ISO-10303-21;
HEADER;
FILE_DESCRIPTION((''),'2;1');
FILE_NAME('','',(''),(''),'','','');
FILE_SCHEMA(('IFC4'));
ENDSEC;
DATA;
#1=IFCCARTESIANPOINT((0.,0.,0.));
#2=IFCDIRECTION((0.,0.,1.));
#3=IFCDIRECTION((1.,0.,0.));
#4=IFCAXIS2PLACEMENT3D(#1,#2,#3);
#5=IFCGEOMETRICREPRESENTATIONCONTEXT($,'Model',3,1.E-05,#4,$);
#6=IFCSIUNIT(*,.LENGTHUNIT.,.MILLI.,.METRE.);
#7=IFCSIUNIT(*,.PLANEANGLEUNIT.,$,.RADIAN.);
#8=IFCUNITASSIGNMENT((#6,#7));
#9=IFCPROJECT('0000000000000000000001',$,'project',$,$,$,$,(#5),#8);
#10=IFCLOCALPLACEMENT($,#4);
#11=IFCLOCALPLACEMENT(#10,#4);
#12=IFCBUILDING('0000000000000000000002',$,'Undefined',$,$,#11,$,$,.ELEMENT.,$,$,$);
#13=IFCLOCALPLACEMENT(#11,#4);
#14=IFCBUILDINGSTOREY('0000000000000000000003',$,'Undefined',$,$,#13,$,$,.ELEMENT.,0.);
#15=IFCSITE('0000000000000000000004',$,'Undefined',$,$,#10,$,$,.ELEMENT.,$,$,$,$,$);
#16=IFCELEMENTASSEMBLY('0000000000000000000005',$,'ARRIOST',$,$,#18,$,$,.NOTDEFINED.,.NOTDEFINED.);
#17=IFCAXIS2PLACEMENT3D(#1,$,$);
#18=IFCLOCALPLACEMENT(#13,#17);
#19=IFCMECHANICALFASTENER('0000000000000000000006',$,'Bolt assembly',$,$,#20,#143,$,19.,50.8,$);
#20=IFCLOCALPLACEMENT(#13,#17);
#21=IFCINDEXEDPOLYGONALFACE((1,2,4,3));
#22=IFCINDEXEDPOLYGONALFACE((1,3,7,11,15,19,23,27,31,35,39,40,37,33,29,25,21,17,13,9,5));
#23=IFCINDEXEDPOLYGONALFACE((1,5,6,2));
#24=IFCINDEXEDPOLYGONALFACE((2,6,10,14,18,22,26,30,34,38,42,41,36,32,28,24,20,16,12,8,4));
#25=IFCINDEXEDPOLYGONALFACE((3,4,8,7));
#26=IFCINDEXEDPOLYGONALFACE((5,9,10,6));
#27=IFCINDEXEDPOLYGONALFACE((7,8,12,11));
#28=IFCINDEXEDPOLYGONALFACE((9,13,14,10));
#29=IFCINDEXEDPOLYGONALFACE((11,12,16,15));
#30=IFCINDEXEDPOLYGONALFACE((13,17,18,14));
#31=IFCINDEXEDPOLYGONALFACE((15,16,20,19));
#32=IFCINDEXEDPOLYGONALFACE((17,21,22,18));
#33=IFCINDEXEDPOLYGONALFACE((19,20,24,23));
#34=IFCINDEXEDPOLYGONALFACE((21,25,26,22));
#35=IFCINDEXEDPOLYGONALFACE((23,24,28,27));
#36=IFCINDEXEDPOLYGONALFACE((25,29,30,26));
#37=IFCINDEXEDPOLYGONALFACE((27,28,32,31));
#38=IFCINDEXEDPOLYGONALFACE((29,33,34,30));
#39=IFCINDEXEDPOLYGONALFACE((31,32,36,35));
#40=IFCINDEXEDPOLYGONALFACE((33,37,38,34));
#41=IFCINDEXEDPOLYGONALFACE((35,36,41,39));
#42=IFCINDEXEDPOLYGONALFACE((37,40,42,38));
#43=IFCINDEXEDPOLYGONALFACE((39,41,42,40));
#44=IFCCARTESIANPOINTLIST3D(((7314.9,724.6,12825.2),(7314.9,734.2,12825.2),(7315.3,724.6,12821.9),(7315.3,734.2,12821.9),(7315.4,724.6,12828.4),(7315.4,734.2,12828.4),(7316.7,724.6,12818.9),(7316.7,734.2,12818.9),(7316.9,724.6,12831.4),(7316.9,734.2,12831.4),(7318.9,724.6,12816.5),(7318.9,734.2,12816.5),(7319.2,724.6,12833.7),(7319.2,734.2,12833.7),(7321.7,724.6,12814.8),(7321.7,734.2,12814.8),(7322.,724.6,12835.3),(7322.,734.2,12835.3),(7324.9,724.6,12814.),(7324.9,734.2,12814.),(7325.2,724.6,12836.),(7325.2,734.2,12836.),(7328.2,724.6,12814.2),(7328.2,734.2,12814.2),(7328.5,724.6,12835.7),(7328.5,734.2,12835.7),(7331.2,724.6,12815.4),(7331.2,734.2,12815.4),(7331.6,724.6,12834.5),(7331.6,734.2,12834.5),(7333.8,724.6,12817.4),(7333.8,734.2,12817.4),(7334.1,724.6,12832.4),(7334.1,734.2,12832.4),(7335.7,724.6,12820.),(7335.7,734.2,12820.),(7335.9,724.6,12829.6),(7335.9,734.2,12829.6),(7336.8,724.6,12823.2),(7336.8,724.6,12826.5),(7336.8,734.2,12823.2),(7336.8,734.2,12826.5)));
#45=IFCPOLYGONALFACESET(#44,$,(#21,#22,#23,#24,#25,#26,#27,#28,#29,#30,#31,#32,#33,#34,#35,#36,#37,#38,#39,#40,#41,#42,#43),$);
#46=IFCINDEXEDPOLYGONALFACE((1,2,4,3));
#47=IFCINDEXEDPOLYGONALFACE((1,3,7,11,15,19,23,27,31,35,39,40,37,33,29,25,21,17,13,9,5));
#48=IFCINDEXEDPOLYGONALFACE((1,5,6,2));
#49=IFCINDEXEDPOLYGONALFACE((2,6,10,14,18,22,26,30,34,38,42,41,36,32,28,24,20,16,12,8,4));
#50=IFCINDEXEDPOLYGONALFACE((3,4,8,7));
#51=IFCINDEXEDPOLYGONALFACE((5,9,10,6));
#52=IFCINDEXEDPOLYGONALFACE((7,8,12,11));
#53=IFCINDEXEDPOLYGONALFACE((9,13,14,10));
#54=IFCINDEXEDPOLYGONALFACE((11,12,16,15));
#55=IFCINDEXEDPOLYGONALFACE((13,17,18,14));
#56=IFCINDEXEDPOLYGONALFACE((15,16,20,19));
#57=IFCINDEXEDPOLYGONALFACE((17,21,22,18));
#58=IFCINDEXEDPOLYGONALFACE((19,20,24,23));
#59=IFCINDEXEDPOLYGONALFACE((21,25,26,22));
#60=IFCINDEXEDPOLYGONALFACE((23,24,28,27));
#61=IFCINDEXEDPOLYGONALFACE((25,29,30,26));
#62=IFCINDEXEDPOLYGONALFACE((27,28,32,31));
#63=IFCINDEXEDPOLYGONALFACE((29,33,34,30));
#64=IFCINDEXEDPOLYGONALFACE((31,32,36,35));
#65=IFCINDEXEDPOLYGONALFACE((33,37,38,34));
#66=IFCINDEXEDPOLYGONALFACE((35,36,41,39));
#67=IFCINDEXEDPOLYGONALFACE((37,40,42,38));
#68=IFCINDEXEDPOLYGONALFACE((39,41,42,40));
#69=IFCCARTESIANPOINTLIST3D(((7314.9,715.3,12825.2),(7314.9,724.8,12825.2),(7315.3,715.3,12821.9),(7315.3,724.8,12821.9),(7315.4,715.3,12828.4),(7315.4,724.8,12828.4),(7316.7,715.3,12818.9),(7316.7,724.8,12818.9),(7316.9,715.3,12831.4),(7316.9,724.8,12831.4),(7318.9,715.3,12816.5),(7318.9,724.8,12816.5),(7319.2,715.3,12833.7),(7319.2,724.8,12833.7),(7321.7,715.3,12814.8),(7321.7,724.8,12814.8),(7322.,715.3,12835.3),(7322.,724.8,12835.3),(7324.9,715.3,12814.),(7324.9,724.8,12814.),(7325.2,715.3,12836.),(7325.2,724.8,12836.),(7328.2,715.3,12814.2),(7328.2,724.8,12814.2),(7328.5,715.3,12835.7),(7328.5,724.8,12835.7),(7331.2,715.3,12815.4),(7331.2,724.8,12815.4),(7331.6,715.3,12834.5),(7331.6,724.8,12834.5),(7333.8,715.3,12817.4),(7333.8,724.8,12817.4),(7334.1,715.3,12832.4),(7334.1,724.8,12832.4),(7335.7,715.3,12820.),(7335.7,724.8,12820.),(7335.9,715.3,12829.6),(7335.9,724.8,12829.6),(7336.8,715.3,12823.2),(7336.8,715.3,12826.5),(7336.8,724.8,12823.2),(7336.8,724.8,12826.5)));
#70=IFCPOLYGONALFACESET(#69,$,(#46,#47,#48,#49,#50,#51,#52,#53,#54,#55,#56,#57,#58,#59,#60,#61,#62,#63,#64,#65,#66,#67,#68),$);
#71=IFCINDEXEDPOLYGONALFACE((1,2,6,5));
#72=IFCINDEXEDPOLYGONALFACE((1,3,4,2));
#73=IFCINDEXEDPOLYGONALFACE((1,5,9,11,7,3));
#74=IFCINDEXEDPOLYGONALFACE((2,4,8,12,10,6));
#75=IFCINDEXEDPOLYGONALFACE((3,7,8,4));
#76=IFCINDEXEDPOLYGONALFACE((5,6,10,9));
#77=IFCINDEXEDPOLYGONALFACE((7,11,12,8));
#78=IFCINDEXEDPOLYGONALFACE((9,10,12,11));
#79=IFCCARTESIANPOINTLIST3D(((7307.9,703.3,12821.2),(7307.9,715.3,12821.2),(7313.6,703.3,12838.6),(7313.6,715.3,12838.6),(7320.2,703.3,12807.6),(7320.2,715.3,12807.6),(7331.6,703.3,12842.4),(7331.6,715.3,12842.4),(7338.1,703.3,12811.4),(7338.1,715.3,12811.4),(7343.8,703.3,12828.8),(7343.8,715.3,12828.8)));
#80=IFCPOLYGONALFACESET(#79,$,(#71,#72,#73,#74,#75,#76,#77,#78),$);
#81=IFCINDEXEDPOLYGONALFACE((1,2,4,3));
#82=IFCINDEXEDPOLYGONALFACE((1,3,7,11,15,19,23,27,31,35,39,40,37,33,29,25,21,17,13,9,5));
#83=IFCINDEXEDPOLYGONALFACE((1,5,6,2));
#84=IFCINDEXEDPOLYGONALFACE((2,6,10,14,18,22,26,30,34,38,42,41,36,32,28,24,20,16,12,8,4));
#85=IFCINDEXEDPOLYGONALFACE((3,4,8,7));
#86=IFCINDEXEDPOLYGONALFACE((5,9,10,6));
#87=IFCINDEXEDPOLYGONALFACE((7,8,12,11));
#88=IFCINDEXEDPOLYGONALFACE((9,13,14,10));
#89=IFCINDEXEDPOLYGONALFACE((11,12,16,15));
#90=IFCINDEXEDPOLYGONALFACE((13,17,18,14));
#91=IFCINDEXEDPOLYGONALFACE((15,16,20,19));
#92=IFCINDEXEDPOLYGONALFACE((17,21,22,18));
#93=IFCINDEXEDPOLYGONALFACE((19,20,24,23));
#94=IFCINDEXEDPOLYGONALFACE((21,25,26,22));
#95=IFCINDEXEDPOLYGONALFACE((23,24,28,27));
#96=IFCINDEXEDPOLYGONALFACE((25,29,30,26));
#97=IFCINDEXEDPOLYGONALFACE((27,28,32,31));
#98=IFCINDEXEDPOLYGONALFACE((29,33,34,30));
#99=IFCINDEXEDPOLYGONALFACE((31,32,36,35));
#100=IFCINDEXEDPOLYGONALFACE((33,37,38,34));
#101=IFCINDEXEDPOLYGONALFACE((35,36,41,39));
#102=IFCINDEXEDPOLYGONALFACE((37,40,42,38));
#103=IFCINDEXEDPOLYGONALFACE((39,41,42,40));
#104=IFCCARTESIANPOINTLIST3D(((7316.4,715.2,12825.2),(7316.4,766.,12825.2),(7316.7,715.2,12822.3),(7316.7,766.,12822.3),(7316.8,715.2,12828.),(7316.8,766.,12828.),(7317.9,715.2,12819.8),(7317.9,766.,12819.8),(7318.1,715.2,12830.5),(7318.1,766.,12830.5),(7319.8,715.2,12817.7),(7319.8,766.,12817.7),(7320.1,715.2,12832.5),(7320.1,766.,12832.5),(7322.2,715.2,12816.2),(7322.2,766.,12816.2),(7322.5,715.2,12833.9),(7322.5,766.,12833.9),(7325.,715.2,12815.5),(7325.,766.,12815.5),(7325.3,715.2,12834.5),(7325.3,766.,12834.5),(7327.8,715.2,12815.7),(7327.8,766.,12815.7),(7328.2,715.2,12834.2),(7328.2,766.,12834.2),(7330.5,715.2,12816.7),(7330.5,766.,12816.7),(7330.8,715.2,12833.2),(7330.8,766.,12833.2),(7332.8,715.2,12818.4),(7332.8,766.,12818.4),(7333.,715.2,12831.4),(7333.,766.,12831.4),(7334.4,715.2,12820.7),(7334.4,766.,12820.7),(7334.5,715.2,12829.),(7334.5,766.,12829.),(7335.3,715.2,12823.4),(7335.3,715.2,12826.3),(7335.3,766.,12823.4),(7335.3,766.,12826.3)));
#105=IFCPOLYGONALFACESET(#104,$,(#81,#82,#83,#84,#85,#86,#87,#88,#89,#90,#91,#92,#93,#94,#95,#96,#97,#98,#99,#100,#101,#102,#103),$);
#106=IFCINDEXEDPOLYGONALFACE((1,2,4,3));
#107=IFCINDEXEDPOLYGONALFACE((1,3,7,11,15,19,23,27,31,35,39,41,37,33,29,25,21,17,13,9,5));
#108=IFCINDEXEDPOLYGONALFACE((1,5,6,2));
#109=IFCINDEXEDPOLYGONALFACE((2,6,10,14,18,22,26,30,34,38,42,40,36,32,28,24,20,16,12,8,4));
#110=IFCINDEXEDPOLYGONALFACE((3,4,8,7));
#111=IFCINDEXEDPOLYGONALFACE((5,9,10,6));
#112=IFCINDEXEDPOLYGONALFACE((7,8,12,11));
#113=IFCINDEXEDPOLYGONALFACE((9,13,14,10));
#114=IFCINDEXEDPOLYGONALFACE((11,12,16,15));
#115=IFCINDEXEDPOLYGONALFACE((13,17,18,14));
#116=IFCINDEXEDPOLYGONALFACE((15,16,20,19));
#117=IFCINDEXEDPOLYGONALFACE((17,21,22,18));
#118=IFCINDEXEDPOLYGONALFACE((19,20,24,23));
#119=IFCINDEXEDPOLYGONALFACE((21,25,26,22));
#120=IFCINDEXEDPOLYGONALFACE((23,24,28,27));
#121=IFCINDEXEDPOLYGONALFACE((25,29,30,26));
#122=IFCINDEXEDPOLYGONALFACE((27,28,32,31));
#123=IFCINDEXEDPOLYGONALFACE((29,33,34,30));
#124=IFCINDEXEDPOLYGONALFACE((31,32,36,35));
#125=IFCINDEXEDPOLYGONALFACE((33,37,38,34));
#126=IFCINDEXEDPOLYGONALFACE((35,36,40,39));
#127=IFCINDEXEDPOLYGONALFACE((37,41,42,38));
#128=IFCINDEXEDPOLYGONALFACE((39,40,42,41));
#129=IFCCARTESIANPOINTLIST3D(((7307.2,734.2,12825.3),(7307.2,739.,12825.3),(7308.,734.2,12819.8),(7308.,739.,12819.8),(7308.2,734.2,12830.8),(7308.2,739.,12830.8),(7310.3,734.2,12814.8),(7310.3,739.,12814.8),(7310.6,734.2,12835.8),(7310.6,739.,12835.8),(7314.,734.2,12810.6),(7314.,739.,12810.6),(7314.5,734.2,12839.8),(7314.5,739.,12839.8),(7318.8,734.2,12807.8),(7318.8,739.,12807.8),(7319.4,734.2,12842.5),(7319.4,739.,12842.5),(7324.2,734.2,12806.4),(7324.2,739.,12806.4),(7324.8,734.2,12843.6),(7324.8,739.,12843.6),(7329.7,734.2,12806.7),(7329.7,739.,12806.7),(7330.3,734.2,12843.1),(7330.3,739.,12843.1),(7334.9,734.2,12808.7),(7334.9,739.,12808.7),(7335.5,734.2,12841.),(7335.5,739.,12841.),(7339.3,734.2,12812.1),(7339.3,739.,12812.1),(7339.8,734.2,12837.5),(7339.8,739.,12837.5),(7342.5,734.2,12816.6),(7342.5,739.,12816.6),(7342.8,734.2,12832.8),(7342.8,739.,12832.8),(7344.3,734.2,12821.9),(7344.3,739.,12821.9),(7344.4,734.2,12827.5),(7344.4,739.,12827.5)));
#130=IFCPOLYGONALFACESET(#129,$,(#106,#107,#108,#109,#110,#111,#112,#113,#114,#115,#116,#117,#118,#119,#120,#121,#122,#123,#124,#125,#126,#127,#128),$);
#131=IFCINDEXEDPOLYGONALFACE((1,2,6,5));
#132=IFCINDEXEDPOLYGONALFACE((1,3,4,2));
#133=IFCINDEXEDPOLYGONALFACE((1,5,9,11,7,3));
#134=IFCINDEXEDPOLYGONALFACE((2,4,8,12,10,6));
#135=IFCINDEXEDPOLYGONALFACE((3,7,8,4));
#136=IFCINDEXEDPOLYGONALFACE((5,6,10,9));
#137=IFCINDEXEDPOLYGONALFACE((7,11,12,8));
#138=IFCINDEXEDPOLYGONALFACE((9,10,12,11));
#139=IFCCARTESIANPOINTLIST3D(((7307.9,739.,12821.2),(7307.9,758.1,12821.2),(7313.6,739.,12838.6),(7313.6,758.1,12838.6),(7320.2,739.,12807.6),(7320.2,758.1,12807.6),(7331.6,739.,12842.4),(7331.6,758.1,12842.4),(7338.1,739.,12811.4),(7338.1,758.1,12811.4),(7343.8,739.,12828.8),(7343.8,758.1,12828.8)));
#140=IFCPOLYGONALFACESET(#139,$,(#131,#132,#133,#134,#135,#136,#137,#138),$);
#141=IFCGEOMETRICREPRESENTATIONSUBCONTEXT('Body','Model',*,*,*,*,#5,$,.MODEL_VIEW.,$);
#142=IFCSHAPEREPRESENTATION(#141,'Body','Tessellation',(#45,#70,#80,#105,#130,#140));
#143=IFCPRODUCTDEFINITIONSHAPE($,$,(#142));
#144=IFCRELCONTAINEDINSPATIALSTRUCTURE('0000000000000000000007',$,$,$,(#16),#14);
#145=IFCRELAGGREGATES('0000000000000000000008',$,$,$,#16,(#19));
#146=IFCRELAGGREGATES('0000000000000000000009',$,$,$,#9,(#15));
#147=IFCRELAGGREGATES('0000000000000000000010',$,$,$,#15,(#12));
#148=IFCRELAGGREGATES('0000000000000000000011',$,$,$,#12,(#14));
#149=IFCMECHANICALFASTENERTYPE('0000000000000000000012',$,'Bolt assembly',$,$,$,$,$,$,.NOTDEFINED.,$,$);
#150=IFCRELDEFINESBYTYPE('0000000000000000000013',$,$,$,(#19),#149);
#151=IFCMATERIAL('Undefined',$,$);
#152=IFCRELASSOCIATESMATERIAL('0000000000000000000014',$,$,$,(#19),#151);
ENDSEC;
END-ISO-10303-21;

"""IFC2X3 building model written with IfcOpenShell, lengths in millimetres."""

from ifc_helpers import new_model, si_unit, frame, origin_with_axes, origin_2d_with_axis, place, context, subcontext, project, spatial, polyline, circle, outline, extrude, source, transform, mapped, material, type_object, element, aggregate, save


model = new_model("IFC2X3")

# Units and contexts
model_context = context("Model", 3, precision=1e-05, world=origin_with_axes())
body_context = subcontext(model_context, "Body", "Model", "MODEL_VIEW")
ifc_project = project(units=[si_unit("LENGTHUNIT", "METRE", prefix="MILLI"), si_unit("PLANEANGLEUNIT", "RADIAN")], contexts=[model_context])

# Site, building, storey
site_placement = place(None, origin_with_axes())
site = spatial("IfcSite", under=ifc_project, at=site_placement, Name="Undefined", CompositionType="ELEMENT")
building_placement = place(site_placement, origin_with_axes())
building = spatial("IfcBuilding", under=site, at=building_placement, Name="Undefined", CompositionType="ELEMENT")
storey_placement = place(building_placement, origin_with_axes())
storey = spatial("IfcBuildingStorey", under=building, at=storey_placement, Name="Undefined", CompositionType="ELEMENT", Elevation=0.0)

# Element assembly
assembly_1_placement = place(storey_placement, origin_with_axes())
assembly_1 = element("IfcElementAssembly", 1, at=assembly_1_placement, inside=storey, Name="ARRIOST", AssemblyPlace="NOTDEFINED", PredefinedType="NOTDEFINED")

# Shared definitions
ifc_material_1 = material(Name="Undefined")
mechanical_fastener_type = type_object("IfcMechanicalFastenerType", Name="Bolt assembly")

# Mechanical fastener
shared_shape_1 = source(origin_with_axes(), body_context, "Body", "SweptSolid", [
    extrude(circle(Radius=11.0, at=origin_2d_with_axis()), frame((0.0, 4.6, 0.0), z_axis=(0.0, 1.0, 0.0), x_axis=(1.0, 0.0, 0.0)), (0.0, 0.0, 1.0), 9.6),
    extrude(circle(Radius=11.0, at=origin_2d_with_axis()), frame((0.0, -4.6, 0.0), z_axis=(0.0, 1.0, 0.0), x_axis=(1.0, 0.0, 0.0)), (0.0, 0.0, 1.0), 9.5),
    extrude(outline(polyline([(15.9, -9.2), (15.9, 9.2), (0.0, 18.3), (-15.9, 9.2), (-15.9, -9.2), (0.0, -18.3), (15.9, -9.2)])), frame((0.0, -16.7, 0.0), z_axis=(0.0, 1.0, 0.0), x_axis=(1.0, 0.0, 0.0)), (0.0, 0.0, 1.0), 11.9),
    extrude(circle(Radius=9.5, at=origin_2d_with_axis()), frame((0.0, -4.7, 0.0), z_axis=(0.0, 1.0, 0.0), x_axis=(1.0, 0.0, 0.0)), (0.0, 0.0, 1.0), 50.8),
    extrude(circle(Radius=18.7, at=origin_2d_with_axis()), frame((0.0, 14.2, 0.0), z_axis=(0.0, 1.0, 0.0), x_axis=(1.0, 0.0, 0.0)), (0.0, 0.0, 1.0), 4.8),
    extrude(outline(polyline([(15.9, -9.2), (15.9, 9.2), (0.0, 18.3), (-15.9, 9.2), (-15.9, -9.2), (0.0, -18.3), (15.9, -9.2)])), frame((0.0, 19.0, 0.0), z_axis=(0.0, 1.0, 0.0), x_axis=(1.0, 0.0, 0.0)), (0.0, 0.0, 1.0), 19.1),
])
mechanical_fastener_1_placement = place(assembly_1_placement, frame((7325.9, 720.0, 12825.0), z_axis=(-0.310857, 0.0, -0.950457), x_axis=(-0.950457, 0.0, 0.310857)))
mechanical_fastener_1 = element("IfcMechanicalFastener", 2, at=mechanical_fastener_1_placement, type_object=mechanical_fastener_type, material=ifc_material_1, Name="Bolt assembly", NominalDiameter=19.0, NominalLength=50.8, context=body_context, shape_type="MappedRepresentation", body=[
    mapped(shared_shape_1, transform((0.0, 0.0, 0.0))),
])
aggregate(assembly_1, [mechanical_fastener_1])

save(model, "model.ifc")
